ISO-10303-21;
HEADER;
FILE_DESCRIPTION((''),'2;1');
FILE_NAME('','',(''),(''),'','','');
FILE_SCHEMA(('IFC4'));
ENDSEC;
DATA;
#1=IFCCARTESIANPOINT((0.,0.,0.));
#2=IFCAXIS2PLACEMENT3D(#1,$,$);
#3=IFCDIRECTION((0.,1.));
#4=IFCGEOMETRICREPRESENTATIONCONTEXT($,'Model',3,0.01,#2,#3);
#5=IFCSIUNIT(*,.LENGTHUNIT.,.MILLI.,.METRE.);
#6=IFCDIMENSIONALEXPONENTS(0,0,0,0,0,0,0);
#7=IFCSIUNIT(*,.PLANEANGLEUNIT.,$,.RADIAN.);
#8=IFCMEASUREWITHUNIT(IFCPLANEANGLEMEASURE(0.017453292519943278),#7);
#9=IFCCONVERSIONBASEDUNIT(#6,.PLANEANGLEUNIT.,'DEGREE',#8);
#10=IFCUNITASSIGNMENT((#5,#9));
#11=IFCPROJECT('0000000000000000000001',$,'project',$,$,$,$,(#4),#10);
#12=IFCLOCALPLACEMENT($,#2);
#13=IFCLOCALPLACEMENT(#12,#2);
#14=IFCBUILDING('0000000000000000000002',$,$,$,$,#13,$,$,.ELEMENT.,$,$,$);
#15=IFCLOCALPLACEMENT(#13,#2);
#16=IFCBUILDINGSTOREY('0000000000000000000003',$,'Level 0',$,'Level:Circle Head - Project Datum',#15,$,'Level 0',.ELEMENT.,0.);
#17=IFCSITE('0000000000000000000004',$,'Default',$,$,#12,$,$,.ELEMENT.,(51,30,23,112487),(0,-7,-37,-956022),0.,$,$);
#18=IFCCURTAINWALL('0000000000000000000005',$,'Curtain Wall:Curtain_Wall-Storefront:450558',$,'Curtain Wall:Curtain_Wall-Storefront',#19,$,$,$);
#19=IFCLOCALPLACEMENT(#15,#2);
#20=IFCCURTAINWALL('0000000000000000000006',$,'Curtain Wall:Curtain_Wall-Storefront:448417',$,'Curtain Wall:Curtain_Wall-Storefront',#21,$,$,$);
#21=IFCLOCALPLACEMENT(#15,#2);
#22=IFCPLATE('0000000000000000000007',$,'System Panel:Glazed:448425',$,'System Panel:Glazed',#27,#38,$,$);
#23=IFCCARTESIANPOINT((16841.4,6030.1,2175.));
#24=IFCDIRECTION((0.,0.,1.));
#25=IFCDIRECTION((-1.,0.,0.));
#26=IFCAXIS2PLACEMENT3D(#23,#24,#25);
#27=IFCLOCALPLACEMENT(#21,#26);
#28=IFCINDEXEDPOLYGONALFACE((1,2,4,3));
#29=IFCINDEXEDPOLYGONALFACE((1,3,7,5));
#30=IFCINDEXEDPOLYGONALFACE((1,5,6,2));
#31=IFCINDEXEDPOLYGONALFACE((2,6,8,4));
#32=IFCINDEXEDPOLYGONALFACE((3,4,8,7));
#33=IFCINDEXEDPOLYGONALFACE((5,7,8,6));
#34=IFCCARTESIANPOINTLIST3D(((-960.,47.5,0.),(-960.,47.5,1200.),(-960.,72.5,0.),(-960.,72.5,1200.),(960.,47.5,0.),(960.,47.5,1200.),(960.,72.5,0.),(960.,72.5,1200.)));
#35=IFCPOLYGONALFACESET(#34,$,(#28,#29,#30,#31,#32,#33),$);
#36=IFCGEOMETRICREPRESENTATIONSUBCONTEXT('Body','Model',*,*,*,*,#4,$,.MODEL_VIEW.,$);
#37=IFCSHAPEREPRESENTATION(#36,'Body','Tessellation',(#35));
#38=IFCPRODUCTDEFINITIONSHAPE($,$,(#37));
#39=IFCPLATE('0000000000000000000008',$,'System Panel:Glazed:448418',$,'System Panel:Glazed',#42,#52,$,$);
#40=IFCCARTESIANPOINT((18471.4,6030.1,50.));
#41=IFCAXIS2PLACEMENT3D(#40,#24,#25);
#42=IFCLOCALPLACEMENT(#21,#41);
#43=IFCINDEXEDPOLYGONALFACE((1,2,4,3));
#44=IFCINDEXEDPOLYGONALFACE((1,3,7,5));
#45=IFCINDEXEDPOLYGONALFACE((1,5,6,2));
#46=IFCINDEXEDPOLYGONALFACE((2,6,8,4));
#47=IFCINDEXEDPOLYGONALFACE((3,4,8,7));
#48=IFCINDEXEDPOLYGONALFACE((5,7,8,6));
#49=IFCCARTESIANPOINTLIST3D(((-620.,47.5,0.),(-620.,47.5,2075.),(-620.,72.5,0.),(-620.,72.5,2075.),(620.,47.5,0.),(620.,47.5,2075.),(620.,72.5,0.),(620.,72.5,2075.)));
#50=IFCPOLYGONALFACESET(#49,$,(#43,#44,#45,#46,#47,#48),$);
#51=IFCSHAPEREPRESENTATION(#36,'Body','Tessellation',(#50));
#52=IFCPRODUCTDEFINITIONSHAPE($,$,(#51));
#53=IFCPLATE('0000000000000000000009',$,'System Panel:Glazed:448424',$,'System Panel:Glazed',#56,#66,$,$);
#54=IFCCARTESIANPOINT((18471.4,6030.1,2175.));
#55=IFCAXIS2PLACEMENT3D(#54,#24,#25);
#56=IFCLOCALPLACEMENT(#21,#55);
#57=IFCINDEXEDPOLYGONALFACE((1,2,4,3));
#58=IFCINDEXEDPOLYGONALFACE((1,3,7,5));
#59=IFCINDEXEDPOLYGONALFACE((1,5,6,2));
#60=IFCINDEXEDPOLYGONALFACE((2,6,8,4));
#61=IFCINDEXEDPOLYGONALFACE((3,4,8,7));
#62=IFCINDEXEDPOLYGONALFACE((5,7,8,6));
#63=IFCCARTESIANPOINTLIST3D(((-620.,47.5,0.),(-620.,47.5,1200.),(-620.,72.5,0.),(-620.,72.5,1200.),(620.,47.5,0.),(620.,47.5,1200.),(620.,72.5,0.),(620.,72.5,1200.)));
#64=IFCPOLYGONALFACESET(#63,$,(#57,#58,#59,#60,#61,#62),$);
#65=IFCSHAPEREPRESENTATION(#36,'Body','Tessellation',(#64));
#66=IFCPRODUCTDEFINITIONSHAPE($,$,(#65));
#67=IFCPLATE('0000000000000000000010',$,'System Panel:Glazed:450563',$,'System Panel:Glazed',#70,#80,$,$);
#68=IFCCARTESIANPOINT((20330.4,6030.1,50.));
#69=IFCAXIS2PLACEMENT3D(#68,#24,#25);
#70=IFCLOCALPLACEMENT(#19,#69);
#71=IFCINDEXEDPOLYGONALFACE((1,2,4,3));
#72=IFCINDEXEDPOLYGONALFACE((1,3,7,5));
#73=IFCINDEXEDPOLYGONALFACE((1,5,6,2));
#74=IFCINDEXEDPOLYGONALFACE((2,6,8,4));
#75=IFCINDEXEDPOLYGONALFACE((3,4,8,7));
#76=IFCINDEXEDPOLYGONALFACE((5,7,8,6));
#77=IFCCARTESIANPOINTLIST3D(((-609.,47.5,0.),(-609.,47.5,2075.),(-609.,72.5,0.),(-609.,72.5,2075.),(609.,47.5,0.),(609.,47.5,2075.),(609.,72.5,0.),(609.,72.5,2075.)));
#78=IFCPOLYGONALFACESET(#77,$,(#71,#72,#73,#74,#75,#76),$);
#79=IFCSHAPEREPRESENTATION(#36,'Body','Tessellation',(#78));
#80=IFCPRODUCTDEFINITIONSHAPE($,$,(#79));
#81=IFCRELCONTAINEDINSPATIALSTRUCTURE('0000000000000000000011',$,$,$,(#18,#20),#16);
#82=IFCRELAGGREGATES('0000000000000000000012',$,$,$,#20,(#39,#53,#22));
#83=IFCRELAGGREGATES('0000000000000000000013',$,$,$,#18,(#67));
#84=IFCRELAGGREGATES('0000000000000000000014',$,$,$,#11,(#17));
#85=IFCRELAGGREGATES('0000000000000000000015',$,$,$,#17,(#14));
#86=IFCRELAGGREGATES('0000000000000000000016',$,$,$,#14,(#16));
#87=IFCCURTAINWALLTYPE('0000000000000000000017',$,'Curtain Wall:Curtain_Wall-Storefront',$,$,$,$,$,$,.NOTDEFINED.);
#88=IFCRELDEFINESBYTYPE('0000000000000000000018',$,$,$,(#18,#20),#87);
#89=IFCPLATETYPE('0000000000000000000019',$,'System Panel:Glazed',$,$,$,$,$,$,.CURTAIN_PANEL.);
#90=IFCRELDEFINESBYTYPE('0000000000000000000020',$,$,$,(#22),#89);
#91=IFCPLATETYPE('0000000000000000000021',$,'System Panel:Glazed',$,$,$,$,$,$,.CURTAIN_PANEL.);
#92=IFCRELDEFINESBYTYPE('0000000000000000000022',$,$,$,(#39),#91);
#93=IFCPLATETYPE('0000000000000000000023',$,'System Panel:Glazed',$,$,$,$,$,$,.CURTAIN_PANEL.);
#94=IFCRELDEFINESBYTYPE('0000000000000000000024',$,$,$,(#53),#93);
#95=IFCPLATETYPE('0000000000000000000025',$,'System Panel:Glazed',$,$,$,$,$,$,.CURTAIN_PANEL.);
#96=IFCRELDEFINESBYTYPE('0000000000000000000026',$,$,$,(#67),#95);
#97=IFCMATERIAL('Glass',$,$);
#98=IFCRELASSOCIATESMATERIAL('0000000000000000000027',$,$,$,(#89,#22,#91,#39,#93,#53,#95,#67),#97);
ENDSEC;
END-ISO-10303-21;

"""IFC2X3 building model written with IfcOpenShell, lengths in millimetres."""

from ifc_helpers import new_model, entity, si_unit, converted_unit, direction, frame, origin, origin_2d_with_axis, place, context, subcontext, project, spatial, rectangle, extrude, source, transform, mapped, material, type_object, type_shapes, element, aggregate, save


model = new_model("IFC2X3")

# Units and contexts
model_context = context("Model", 3, precision=0.01, world=origin(), true_north=direction((0.0, 1.0)))
body_context = subcontext(model_context, "Body", "Model", "MODEL_VIEW")
ifc_project = project(units=[si_unit("LENGTHUNIT", "METRE", prefix="MILLI"), converted_unit("PLANEANGLEUNIT", "DEGREE", entity("IfcPlaneAngleMeasure", 0.017453292519943278), si_unit("PLANEANGLEUNIT", "RADIAN"), dimensions=[0, 0, 0, 0, 0, 0, 0])], contexts=[model_context])

# Site, building, storey
site_placement = place(None, origin())
site = spatial("IfcSite", under=ifc_project, at=site_placement, Name="Default", CompositionType="ELEMENT", RefLatitude=(51, 30, 23, 112487), RefLongitude=(0, -7, -37, -956022), RefElevation=0.0)
building_placement = place(site_placement, origin())
building = spatial("IfcBuilding", under=site, at=building_placement, CompositionType="ELEMENT")
storey_placement = place(building_placement, origin())
storey = spatial("IfcBuildingStorey", under=building, at=storey_placement, Name="Level 0", ObjectType="Level:Circle Head - Project Datum", LongName="Level 0", CompositionType="ELEMENT", Elevation=0.0)

# Curtain walls
curtain_wall_type = type_object("IfcCurtainWallType", Name="Curtain Wall:Curtain_Wall-Storefront", PredefinedType="NOTDEFINED")
curtain_wall_1_placement = place(storey_placement, origin())
curtain_wall_1 = element("IfcCurtainWall", 1, at=curtain_wall_1_placement, inside=storey, type_object=curtain_wall_type, Name="Curtain Wall:Curtain_Wall-Storefront:450558", ObjectType="Curtain Wall:Curtain_Wall-Storefront")
curtain_wall_2_placement = place(storey_placement, origin())
curtain_wall_2 = element("IfcCurtainWall", 2, at=curtain_wall_2_placement, inside=storey, type_object=curtain_wall_type, Name="Curtain Wall:Curtain_Wall-Storefront:448417", ObjectType="Curtain Wall:Curtain_Wall-Storefront")

# Plates
ifc_material_1 = material(Name="Glass")
plate_type_1 = type_object("IfcPlateType", Name="System Panel:Glazed", PredefinedType="CURTAIN_PANEL", material=ifc_material_1)
shared_shape_1 = source(origin(), body_context, "Body", "SweptSolid", [
    extrude(rectangle(XDim=25.0, YDim=1920.0, at=origin_2d_with_axis()), frame((0.0, 60.0, 0.0), z_axis=(0.0, 0.0, 1.0), x_axis=(0.0, 1.0, 0.0)), (0.0, 0.0, 1.0), 1200.0),
])
type_shapes(plate_type_1, [shared_shape_1])
plate_1_placement = place(curtain_wall_2_placement, frame((16841.4, 6030.1, 2175.0), z_axis=(0.0, 0.0, 1.0), x_axis=(-1.0, 0.0, 0.0)))
plate_1 = element("IfcPlate", 3, at=plate_1_placement, type_object=plate_type_1, material=ifc_material_1, Name="System Panel:Glazed:448425", ObjectType="System Panel:Glazed", context=body_context, shape_type="MappedRepresentation", body=[
    mapped(shared_shape_1, transform((0.0, 0.0, 0.0), scale=1.0)),
])
plate_type_2 = type_object("IfcPlateType", Name="System Panel:Glazed", PredefinedType="CURTAIN_PANEL", material=ifc_material_1)
shared_shape_2 = source(origin(), body_context, "Body", "SweptSolid", [
    extrude(rectangle(XDim=25.0, YDim=1240.0, at=origin_2d_with_axis()), frame((0.0, 60.0, 0.0), z_axis=(0.0, 0.0, 1.0), x_axis=(0.0, 1.0, 0.0)), (0.0, 0.0, 1.0), 2075.0),
])
type_shapes(plate_type_2, [shared_shape_2])
plate_2_placement = place(curtain_wall_2_placement, frame((18471.4, 6030.1, 50.0), z_axis=(0.0, 0.0, 1.0), x_axis=(-1.0, 0.0, 0.0)))
plate_2 = element("IfcPlate", 4, at=plate_2_placement, type_object=plate_type_2, material=ifc_material_1, Name="System Panel:Glazed:448418", ObjectType="System Panel:Glazed", context=body_context, shape_type="MappedRepresentation", body=[
    mapped(shared_shape_2, transform((0.0, 0.0, 0.0), scale=1.0)),
])
plate_type_3 = type_object("IfcPlateType", Name="System Panel:Glazed", PredefinedType="CURTAIN_PANEL", material=ifc_material_1)
shared_shape_3 = source(origin(), body_context, "Body", "SweptSolid", [
    extrude(rectangle(XDim=25.0, YDim=1240.0, at=origin_2d_with_axis()), frame((0.0, 60.0, 0.0), z_axis=(0.0, 0.0, 1.0), x_axis=(0.0, 1.0, 0.0)), (0.0, 0.0, 1.0), 1200.0),
])
type_shapes(plate_type_3, [shared_shape_3])
plate_3_placement = place(curtain_wall_2_placement, frame((18471.4, 6030.1, 2175.0), z_axis=(0.0, 0.0, 1.0), x_axis=(-1.0, 0.0, 0.0)))
plate_3 = element("IfcPlate", 5, at=plate_3_placement, type_object=plate_type_3, material=ifc_material_1, Name="System Panel:Glazed:448424", ObjectType="System Panel:Glazed", context=body_context, shape_type="MappedRepresentation", body=[
    mapped(shared_shape_3, transform((0.0, 0.0, 0.0), scale=1.0)),
])
aggregate(curtain_wall_2, [plate_2, plate_3, plate_1])
plate_type_4 = type_object("IfcPlateType", Name="System Panel:Glazed", PredefinedType="CURTAIN_PANEL", material=ifc_material_1)
shared_shape_4 = source(origin(), body_context, "Body", "SweptSolid", [
    extrude(rectangle(XDim=25.0, YDim=1218.0, at=origin_2d_with_axis()), frame((0.0, 60.0, 0.0), z_axis=(0.0, 0.0, 1.0), x_axis=(0.0, 1.0, 0.0)), (0.0, 0.0, 1.0), 2075.0),
])
type_shapes(plate_type_4, [shared_shape_4])
plate_4_placement = place(curtain_wall_1_placement, frame((20330.4, 6030.1, 50.0), z_axis=(0.0, 0.0, 1.0), x_axis=(-1.0, 0.0, 0.0)))
plate_4 = element("IfcPlate", 6, at=plate_4_placement, type_object=plate_type_4, material=ifc_material_1, Name="System Panel:Glazed:450563", ObjectType="System Panel:Glazed", context=body_context, shape_type="MappedRepresentation", body=[
    mapped(shared_shape_4, transform((0.0, 0.0, 0.0), scale=1.0)),
])
aggregate(curtain_wall_1, [plate_4])

save(model, "model.ifc")
